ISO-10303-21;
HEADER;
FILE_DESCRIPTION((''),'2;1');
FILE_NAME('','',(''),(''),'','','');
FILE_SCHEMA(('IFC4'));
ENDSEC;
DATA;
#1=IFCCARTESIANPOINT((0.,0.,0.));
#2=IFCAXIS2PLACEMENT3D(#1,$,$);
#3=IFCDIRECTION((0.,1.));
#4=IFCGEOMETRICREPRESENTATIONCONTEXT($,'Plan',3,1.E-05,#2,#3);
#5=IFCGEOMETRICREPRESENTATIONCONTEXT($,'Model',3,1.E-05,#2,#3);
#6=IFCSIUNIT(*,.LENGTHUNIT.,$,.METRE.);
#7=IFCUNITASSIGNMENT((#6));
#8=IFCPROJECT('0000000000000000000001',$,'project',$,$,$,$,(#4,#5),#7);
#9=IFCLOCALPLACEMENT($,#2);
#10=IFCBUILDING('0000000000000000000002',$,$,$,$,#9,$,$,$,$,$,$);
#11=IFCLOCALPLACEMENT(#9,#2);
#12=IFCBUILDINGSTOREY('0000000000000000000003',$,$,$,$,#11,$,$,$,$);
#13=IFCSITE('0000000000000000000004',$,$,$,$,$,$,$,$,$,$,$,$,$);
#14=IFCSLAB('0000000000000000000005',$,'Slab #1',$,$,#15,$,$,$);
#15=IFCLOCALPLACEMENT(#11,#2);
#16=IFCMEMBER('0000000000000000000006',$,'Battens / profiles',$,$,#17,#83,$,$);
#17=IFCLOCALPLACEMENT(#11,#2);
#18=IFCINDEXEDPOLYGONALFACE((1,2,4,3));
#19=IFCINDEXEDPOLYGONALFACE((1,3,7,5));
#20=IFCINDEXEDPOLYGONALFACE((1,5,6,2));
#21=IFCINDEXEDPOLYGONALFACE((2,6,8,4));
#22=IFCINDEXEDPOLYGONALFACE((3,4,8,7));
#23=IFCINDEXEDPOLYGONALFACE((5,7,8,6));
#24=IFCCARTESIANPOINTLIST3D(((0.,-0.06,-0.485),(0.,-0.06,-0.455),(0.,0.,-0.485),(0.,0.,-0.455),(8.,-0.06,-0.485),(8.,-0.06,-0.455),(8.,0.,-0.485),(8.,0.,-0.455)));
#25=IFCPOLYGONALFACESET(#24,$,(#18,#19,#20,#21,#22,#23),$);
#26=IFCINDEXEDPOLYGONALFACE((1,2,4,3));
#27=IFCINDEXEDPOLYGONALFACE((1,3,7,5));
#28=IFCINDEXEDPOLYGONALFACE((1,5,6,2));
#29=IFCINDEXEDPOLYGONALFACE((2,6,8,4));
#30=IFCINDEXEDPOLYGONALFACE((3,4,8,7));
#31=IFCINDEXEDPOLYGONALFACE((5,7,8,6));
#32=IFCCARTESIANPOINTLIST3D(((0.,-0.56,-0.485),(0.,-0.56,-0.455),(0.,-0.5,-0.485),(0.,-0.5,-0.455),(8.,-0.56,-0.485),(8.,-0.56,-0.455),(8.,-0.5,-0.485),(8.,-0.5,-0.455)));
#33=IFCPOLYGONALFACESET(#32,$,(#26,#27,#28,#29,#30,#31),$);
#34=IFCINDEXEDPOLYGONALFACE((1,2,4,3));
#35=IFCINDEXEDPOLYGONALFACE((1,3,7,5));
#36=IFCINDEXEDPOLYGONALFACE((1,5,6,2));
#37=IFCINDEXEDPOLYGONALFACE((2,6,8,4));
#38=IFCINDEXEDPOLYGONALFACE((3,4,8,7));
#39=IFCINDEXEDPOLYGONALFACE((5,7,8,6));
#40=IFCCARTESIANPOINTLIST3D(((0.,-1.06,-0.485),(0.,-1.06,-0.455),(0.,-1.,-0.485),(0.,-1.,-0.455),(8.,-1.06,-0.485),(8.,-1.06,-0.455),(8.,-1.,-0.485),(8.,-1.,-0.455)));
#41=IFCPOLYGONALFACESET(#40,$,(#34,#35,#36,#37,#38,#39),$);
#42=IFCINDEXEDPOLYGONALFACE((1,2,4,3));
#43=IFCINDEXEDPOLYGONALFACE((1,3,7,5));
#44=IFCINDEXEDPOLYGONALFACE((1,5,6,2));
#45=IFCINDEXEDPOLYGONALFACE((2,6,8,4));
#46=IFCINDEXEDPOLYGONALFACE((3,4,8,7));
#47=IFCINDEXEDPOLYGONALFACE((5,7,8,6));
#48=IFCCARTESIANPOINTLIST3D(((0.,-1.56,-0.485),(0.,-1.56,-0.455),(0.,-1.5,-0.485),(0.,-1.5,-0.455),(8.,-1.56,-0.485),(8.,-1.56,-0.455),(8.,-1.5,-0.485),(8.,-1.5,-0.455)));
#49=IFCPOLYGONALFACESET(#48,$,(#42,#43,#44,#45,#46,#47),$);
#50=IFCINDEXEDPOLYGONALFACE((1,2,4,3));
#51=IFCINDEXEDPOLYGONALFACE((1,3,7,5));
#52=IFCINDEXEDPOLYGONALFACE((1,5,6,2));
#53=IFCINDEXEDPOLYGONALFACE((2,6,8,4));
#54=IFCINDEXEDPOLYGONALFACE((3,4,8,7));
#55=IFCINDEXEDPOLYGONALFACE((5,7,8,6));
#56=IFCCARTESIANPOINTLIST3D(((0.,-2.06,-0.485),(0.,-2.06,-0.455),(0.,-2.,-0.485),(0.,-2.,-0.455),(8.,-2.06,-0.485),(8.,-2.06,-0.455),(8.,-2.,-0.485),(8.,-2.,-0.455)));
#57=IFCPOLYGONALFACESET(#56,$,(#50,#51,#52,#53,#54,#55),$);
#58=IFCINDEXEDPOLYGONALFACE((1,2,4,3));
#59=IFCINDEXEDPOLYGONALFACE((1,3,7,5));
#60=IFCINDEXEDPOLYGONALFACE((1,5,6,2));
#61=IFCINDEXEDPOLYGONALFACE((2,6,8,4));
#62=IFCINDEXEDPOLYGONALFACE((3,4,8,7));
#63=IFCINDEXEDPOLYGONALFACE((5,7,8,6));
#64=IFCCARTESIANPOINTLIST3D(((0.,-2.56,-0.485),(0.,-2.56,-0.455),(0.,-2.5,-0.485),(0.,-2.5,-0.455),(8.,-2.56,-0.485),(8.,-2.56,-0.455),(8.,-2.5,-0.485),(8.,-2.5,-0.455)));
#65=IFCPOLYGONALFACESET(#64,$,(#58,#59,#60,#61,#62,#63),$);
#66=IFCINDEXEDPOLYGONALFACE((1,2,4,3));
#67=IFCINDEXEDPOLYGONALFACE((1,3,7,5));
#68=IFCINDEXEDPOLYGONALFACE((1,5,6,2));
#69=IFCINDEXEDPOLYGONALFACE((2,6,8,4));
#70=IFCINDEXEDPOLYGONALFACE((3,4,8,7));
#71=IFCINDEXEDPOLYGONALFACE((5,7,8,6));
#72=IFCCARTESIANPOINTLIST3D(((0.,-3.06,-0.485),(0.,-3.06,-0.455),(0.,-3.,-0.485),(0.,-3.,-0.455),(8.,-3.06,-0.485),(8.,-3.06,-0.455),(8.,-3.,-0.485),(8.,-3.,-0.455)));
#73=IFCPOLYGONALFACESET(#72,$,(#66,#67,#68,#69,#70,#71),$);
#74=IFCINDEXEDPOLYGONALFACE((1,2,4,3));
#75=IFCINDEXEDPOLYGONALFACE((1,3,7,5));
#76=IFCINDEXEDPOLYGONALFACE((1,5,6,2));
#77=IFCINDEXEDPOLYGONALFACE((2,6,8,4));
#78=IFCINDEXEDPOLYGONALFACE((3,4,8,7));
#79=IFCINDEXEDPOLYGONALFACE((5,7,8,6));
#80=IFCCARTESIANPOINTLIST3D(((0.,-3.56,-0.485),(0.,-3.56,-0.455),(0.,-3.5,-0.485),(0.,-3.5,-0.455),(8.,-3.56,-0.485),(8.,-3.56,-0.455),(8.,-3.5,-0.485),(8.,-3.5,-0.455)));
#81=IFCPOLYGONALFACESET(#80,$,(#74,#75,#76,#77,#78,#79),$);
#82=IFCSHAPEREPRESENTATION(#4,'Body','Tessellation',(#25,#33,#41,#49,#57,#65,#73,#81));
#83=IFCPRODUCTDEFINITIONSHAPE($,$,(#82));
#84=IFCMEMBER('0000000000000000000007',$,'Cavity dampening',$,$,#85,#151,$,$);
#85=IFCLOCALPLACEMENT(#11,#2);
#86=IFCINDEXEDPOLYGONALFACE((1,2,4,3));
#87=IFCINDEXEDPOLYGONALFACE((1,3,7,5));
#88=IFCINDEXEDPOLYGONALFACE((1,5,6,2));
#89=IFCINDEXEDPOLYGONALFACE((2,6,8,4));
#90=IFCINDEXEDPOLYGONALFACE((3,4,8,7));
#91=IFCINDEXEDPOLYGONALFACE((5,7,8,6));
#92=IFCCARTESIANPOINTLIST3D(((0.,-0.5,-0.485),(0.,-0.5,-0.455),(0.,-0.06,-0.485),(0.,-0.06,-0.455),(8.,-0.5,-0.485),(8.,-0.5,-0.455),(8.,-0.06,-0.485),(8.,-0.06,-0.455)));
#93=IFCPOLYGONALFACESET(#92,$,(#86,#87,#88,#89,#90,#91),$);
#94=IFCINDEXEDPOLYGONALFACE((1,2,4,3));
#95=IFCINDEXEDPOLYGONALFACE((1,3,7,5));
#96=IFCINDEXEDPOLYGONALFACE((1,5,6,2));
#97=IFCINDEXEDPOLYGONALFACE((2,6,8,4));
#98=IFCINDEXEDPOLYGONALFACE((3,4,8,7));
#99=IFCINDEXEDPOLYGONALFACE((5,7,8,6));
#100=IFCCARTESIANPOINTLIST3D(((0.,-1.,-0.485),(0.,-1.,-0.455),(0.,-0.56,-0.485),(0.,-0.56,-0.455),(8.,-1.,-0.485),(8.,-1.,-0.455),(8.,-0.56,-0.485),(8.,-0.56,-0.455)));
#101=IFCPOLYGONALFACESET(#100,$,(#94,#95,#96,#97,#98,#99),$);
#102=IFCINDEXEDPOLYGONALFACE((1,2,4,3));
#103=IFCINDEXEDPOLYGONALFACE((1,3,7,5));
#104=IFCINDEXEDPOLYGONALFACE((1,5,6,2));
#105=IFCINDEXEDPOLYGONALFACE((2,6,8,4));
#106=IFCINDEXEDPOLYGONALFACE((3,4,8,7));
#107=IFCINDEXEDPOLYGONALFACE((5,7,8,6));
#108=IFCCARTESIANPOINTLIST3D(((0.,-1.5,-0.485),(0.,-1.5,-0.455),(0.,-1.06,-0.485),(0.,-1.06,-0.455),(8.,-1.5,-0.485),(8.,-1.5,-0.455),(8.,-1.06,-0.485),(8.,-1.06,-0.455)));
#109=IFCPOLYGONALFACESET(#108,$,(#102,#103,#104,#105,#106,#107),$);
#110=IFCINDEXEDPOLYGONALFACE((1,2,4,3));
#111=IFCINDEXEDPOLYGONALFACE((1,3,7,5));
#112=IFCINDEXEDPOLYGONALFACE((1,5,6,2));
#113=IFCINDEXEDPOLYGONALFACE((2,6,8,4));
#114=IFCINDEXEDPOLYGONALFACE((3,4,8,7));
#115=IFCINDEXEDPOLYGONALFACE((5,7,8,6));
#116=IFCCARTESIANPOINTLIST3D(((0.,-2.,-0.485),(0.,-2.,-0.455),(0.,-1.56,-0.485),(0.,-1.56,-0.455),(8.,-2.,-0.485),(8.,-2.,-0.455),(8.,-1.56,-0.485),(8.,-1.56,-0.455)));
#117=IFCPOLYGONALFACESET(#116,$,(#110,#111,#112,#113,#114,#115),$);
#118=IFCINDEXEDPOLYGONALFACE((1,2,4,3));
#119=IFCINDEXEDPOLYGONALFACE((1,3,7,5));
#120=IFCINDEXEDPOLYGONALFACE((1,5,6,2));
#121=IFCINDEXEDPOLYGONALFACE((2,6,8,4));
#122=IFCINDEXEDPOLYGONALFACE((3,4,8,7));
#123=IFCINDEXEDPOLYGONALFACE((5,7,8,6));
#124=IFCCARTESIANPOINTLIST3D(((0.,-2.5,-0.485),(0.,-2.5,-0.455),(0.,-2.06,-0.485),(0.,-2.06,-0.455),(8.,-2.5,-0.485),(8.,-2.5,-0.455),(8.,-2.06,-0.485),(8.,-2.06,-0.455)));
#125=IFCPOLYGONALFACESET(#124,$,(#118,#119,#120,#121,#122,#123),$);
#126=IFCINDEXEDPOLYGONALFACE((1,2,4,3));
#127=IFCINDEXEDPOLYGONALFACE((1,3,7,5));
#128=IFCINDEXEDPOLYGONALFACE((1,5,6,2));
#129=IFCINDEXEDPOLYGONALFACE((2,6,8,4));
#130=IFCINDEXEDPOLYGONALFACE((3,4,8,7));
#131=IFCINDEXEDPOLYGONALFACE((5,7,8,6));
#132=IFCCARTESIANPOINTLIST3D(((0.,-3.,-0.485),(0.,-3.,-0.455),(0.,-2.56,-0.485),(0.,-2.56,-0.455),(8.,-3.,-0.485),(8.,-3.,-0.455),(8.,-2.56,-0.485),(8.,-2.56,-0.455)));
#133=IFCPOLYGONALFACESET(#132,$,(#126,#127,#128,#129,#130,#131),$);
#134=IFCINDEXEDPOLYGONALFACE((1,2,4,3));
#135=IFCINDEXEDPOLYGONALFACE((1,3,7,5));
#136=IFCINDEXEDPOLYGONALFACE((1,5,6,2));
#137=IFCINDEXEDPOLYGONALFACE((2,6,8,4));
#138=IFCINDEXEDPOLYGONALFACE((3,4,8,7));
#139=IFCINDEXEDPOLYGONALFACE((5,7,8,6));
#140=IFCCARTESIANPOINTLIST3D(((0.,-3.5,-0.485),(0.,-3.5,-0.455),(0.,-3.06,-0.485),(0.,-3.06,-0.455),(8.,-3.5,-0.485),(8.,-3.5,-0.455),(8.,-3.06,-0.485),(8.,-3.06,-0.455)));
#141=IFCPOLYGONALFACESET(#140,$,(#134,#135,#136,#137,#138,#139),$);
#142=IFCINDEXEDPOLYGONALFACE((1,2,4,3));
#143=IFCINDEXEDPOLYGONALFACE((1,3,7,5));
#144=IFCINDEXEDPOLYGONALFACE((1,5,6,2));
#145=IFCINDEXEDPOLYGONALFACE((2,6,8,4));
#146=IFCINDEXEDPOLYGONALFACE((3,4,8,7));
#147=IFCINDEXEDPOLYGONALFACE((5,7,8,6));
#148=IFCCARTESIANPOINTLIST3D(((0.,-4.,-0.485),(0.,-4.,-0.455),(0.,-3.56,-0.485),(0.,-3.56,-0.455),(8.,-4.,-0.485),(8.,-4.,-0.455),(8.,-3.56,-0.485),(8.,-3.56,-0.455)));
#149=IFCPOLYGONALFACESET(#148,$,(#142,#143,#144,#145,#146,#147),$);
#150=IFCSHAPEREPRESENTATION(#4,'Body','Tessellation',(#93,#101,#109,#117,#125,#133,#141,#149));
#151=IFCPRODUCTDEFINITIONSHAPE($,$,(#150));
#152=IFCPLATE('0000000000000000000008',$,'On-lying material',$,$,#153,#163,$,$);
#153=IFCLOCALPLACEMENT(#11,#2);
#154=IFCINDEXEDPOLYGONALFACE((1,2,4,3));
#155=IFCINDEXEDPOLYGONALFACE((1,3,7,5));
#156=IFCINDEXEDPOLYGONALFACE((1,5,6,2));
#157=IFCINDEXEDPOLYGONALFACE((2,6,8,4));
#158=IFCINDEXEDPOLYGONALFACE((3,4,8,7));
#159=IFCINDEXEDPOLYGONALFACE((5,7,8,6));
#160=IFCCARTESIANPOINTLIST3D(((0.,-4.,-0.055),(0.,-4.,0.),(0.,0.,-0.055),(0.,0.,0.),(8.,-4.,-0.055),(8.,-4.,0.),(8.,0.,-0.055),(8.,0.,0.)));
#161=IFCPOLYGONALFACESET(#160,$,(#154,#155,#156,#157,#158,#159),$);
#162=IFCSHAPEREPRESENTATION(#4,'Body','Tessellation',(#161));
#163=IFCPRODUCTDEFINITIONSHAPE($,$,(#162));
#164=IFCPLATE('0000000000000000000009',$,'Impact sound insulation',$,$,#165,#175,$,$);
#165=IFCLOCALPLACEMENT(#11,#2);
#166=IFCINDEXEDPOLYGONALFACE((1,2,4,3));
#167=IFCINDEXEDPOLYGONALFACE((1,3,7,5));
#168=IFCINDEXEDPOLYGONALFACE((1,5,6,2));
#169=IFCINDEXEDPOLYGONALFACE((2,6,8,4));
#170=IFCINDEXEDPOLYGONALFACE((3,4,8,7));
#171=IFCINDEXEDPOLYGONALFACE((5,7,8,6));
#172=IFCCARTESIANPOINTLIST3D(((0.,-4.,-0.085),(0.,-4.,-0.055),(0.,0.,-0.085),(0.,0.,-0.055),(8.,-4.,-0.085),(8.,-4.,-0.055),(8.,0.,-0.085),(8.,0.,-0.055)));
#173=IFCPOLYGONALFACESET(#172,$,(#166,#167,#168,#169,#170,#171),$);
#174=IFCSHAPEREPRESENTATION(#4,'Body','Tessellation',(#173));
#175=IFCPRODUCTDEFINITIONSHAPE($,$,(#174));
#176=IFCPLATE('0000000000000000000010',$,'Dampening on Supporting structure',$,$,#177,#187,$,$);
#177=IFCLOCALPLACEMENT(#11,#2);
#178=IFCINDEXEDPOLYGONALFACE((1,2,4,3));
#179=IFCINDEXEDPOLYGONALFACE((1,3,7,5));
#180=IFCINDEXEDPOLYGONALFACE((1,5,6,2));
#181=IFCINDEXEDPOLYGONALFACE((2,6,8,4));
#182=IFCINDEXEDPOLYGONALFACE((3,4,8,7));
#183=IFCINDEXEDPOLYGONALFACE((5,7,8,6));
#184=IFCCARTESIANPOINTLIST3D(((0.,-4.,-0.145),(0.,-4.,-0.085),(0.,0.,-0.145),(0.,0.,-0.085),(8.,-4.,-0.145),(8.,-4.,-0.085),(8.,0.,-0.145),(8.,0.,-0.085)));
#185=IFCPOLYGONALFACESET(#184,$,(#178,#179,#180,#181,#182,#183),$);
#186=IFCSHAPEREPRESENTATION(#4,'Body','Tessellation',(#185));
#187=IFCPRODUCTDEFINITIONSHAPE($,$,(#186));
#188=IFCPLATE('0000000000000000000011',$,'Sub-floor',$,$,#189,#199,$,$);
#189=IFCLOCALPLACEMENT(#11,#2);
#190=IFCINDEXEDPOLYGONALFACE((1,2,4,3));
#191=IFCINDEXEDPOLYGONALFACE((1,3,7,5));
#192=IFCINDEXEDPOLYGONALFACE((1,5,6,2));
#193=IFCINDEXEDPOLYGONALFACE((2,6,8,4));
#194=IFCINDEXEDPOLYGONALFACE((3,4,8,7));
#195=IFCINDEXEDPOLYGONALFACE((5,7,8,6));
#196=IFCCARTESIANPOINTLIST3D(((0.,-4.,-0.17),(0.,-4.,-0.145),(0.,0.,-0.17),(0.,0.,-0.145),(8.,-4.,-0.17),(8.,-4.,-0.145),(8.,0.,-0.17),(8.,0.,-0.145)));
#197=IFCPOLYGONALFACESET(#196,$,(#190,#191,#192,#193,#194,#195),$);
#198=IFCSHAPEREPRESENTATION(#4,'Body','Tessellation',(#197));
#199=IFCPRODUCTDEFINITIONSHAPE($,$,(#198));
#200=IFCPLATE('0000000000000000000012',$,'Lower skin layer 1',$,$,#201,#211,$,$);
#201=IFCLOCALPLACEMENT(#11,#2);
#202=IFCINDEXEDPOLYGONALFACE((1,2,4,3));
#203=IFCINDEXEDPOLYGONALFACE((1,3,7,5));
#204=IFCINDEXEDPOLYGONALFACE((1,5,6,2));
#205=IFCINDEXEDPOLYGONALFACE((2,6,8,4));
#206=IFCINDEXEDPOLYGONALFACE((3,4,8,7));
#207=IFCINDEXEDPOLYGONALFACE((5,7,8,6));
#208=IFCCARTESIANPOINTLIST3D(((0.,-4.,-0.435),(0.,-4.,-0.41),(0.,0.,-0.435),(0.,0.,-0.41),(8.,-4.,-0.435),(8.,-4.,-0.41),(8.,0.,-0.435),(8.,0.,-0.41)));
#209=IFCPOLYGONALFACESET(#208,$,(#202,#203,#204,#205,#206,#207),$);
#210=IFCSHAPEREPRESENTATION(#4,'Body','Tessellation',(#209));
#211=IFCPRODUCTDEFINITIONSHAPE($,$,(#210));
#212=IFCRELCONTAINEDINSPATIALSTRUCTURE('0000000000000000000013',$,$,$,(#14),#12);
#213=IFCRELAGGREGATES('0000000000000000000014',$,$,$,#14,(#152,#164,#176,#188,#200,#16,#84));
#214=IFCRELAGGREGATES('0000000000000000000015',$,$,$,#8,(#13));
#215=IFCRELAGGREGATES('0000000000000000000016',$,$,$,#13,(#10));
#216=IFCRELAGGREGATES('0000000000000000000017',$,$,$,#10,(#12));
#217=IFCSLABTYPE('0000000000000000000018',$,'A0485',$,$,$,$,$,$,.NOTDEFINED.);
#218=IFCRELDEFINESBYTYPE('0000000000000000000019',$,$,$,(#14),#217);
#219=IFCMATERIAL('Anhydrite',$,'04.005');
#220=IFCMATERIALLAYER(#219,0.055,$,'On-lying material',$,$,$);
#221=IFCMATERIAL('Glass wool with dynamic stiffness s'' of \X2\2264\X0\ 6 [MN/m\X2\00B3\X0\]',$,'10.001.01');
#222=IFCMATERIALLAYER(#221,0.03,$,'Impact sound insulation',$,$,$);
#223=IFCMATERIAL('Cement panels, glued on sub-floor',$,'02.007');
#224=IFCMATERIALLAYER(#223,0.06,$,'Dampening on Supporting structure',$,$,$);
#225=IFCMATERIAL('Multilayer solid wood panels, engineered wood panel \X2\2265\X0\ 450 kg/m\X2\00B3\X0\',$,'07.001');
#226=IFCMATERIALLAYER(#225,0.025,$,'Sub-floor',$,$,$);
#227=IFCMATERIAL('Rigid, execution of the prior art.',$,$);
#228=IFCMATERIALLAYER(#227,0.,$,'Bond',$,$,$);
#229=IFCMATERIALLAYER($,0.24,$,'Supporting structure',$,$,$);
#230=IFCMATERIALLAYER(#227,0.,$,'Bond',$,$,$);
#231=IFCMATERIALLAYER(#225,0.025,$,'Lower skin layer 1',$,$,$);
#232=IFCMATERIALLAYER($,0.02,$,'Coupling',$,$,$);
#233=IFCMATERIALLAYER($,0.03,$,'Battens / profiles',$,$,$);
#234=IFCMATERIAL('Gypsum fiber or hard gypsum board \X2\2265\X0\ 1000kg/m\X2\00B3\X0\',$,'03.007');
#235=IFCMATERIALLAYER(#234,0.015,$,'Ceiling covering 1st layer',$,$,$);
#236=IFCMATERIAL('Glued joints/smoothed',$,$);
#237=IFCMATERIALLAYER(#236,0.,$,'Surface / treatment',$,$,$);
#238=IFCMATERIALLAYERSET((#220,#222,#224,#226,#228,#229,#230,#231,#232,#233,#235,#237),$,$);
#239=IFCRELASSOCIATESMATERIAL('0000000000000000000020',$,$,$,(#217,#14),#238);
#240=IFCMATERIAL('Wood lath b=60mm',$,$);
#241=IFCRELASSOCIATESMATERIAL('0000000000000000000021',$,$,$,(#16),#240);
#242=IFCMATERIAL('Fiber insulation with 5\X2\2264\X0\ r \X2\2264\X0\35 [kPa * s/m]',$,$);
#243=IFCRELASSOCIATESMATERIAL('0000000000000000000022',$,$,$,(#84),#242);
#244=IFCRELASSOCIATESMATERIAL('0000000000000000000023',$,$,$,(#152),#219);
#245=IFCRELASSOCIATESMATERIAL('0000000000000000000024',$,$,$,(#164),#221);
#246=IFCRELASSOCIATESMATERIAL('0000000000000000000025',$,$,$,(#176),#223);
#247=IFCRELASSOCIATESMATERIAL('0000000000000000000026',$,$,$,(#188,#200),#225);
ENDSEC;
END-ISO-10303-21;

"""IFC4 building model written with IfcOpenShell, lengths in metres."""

from ifc_helpers import new_model, si_unit, direction, frame, frame_2d, origin, origin_with_axes, place, context, project, spatial, rectangle, extrude, material, layer, layer_set, type_object, element, aggregate, save


model = new_model("IFC4")

# Units and contexts
plan_context = context("Plan", 3, precision=1e-05, world=origin(), true_north=direction((0.0, 1.0)))
model_context = context("Model", 3, precision=1e-05, world=origin(), true_north=direction((0.0, 1.0)))
ifc_project = project(units=[si_unit("LENGTHUNIT", "METRE")], contexts=[plan_context, model_context])

# Site, building, storey
site = spatial("IfcSite", under=ifc_project)
building_placement = place(None, origin())
building = spatial("IfcBuilding", under=site, at=building_placement)
storey_placement = place(building_placement, origin())
storey = spatial("IfcBuildingStorey", under=building, at=storey_placement)

# Slab, members, plates
ifc_material_1 = material(Name="Anhydrite", Category="04.005")
ifc_layer_1 = layer(ifc_material_1, 0.055, Name="On-lying material")
ifc_material_2 = material(Name="Glass wool with dynamic stiffness s' of ≤ 6 [MN/m³]", Category="10.001.01")
ifc_layer_2 = layer(ifc_material_2, 0.03, Name="Impact sound insulation")
ifc_material_3 = material(Name="Cement panels, glued on sub-floor", Category="02.007")
ifc_layer_3 = layer(ifc_material_3, 0.06, Name="Dampening on Supporting structure")
ifc_material_4 = material(Name="Multilayer solid wood panels, engineered wood panel ≥ 450 kg/m³", Category="07.001")
ifc_layer_4 = layer(ifc_material_4, 0.025, Name="Sub-floor")
ifc_material_5 = material(Name="Rigid, execution of the prior art.")
ifc_layer_5 = layer(ifc_material_5, 0.0, Name="Bond")
ifc_layer_6 = layer(None, 0.24, Name="Supporting structure")
ifc_layer_7 = layer(ifc_material_5, 0.0, Name="Bond")
ifc_layer_8 = layer(ifc_material_4, 0.025, Name="Lower skin layer 1")
ifc_layer_9 = layer(None, 0.02, Name="Coupling")
ifc_layer_10 = layer(None, 0.03, Name="Battens / profiles")
ifc_material_6 = material(Name="Gypsum fiber or hard gypsum board ≥ 1000kg/m³", Category="03.007")
ifc_layer_11 = layer(ifc_material_6, 0.015, Name="Ceiling covering 1st layer")
ifc_material_7 = material(Name="Glued joints/smoothed")
ifc_layer_12 = layer(ifc_material_7, 0.0, Name="Surface / treatment")
ifc_layer_set = layer_set([ifc_layer_1, ifc_layer_2, ifc_layer_3, ifc_layer_4, ifc_layer_5, ifc_layer_6, ifc_layer_7, ifc_layer_8, ifc_layer_9, ifc_layer_10, ifc_layer_11, ifc_layer_12])
slab_type = type_object("IfcSlabType", Name="A0485", PredefinedType="NOTDEFINED", material=ifc_layer_set)
slab_placement = place(None, frame((0.0, 0.0, 0.0), z_axis=(0.0, 0.0, -1.0), x_axis=(1.0, 0.0, 0.0)))
slab = element("IfcSlab", 1, at=slab_placement, inside=storey, type_object=slab_type, material=ifc_layer_set, Name="Slab #1")
ifc_material_8 = material(Name="Fiber insulation with 5≤ r ≤35 [kPa * s/m]")
ifc_material_9 = material(Name="Wood lath b=60mm")
member_1_placement = place(slab_placement, origin())
member_1 = element("IfcMember", 2, at=member_1_placement, material=ifc_material_9, Name="Battens / profiles", context=plan_context, shape_type="SweptSolid", body=[
    extrude(rectangle(XDim=0.06, YDim=0.03, at=frame_2d((0.03, 0.015), x_axis=(1.0, 0.0))), frame((0.0, 0.0, 0.455), z_axis=(1.0, 0.0, 0.0), x_axis=(0.0, 1.0, 0.0)), (0.0, 0.0, 1.0), 8.0),
    extrude(rectangle(XDim=0.06, YDim=0.03, at=frame_2d((0.03, 0.015), x_axis=(1.0, 0.0))), frame((0.0, 0.5, 0.455), z_axis=(1.0, 0.0, 0.0), x_axis=(0.0, 1.0, 0.0)), (0.0, 0.0, 1.0), 8.0),
    extrude(rectangle(XDim=0.06, YDim=0.03, at=frame_2d((0.03, 0.015), x_axis=(1.0, 0.0))), frame((0.0, 1.0, 0.455), z_axis=(1.0, 0.0, 0.0), x_axis=(0.0, 1.0, 0.0)), (0.0, 0.0, 1.0), 8.0),
    extrude(rectangle(XDim=0.06, YDim=0.03, at=frame_2d((0.03, 0.015), x_axis=(1.0, 0.0))), frame((0.0, 1.5, 0.455), z_axis=(1.0, 0.0, 0.0), x_axis=(0.0, 1.0, 0.0)), (0.0, 0.0, 1.0), 8.0),
    extrude(rectangle(XDim=0.06, YDim=0.03, at=frame_2d((0.03, 0.015), x_axis=(1.0, 0.0))), frame((0.0, 2.0, 0.455), z_axis=(1.0, 0.0, 0.0), x_axis=(0.0, 1.0, 0.0)), (0.0, 0.0, 1.0), 8.0),
    extrude(rectangle(XDim=0.06, YDim=0.03, at=frame_2d((0.03, 0.015), x_axis=(1.0, 0.0))), frame((0.0, 2.5, 0.455), z_axis=(1.0, 0.0, 0.0), x_axis=(0.0, 1.0, 0.0)), (0.0, 0.0, 1.0), 8.0),
    extrude(rectangle(XDim=0.06, YDim=0.03, at=frame_2d((0.03, 0.015), x_axis=(1.0, 0.0))), frame((0.0, 3.0, 0.455), z_axis=(1.0, 0.0, 0.0), x_axis=(0.0, 1.0, 0.0)), (0.0, 0.0, 1.0), 8.0),
    extrude(rectangle(XDim=0.06, YDim=0.03, at=frame_2d((0.03, 0.015), x_axis=(1.0, 0.0))), frame((0.0, 3.5, 0.455), z_axis=(1.0, 0.0, 0.0), x_axis=(0.0, 1.0, 0.0)), (0.0, 0.0, 1.0), 8.0),
])
member_2_placement = place(slab_placement, origin())
member_2 = element("IfcMember", 3, at=member_2_placement, material=ifc_material_8, Name="Cavity dampening", context=plan_context, shape_type="SweptSolid", body=[
    extrude(rectangle(XDim=0.44, YDim=0.03, at=frame_2d((0.22, 0.015), x_axis=(1.0, 0.0))), frame((0.0, 0.06, 0.455), z_axis=(1.0, 0.0, 0.0), x_axis=(0.0, 1.0, 0.0)), (0.0, 0.0, 1.0), 8.0),
    extrude(rectangle(XDim=0.44, YDim=0.03, at=frame_2d((0.22, 0.015), x_axis=(1.0, 0.0))), frame((0.0, 0.56, 0.455), z_axis=(1.0, 0.0, 0.0), x_axis=(0.0, 1.0, 0.0)), (0.0, 0.0, 1.0), 8.0),
    extrude(rectangle(XDim=0.44, YDim=0.03, at=frame_2d((0.22, 0.015), x_axis=(1.0, 0.0))), frame((0.0, 1.06, 0.455), z_axis=(1.0, 0.0, 0.0), x_axis=(0.0, 1.0, 0.0)), (0.0, 0.0, 1.0), 8.0),
    extrude(rectangle(XDim=0.44, YDim=0.03, at=frame_2d((0.22, 0.015), x_axis=(1.0, 0.0))), frame((0.0, 1.56, 0.455), z_axis=(1.0, 0.0, 0.0), x_axis=(0.0, 1.0, 0.0)), (0.0, 0.0, 1.0), 8.0),
    extrude(rectangle(XDim=0.44, YDim=0.03, at=frame_2d((0.22, 0.015), x_axis=(1.0, 0.0))), frame((0.0, 2.06, 0.455), z_axis=(1.0, 0.0, 0.0), x_axis=(0.0, 1.0, 0.0)), (0.0, 0.0, 1.0), 8.0),
    extrude(rectangle(XDim=0.44, YDim=0.03, at=frame_2d((0.22, 0.015), x_axis=(1.0, 0.0))), frame((0.0, 2.56, 0.455), z_axis=(1.0, 0.0, 0.0), x_axis=(0.0, 1.0, 0.0)), (0.0, 0.0, 1.0), 8.0),
    extrude(rectangle(XDim=0.44, YDim=0.03, at=frame_2d((0.22, 0.015), x_axis=(1.0, 0.0))), frame((0.0, 3.06, 0.455), z_axis=(1.0, 0.0, 0.0), x_axis=(0.0, 1.0, 0.0)), (0.0, 0.0, 1.0), 8.0),
    extrude(rectangle(XDim=0.44, YDim=0.03, at=frame_2d((0.22, 0.015), x_axis=(1.0, 0.0))), frame((0.0, 3.56, 0.455), z_axis=(1.0, 0.0, 0.0), x_axis=(0.0, 1.0, 0.0)), (0.0, 0.0, 1.0), 8.0),
])
plate_1_placement = place(slab_placement, origin())
plate_1 = element("IfcPlate", 4, at=plate_1_placement, material=ifc_material_1, Name="On-lying material", context=plan_context, shape_type="SweptSolid", body=[
    extrude(rectangle(XDim=8.0, YDim=4.0, at=frame_2d((4.0, 2.0), x_axis=(1.0, 0.0))), origin_with_axes(), (0.0, 0.0, 1.0), 0.055),
])
plate_2_placement = place(slab_placement, origin())
plate_2 = element("IfcPlate", 5, at=plate_2_placement, material=ifc_material_2, Name="Impact sound insulation", context=plan_context, shape_type="SweptSolid", body=[
    extrude(rectangle(XDim=8.0, YDim=4.0, at=frame_2d((4.0, 2.0), x_axis=(1.0, 0.0))), frame((0.0, 0.0, 0.055), z_axis=(0.0, 0.0, 1.0), x_axis=(1.0, 0.0, 0.0)), (0.0, 0.0, 1.0), 0.03),
])
plate_3_placement = place(slab_placement, origin())
plate_3 = element("IfcPlate", 6, at=plate_3_placement, material=ifc_material_3, Name="Dampening on Supporting structure", context=plan_context, shape_type="SweptSolid", body=[
    extrude(rectangle(XDim=8.0, YDim=4.0, at=frame_2d((4.0, 2.0), x_axis=(1.0, 0.0))), frame((0.0, 0.0, 0.085), z_axis=(0.0, 0.0, 1.0), x_axis=(1.0, 0.0, 0.0)), (0.0, 0.0, 1.0), 0.06),
])
plate_4_placement = place(slab_placement, origin())
plate_4 = element("IfcPlate", 7, at=plate_4_placement, material=ifc_material_4, Name="Sub-floor", context=plan_context, shape_type="SweptSolid", body=[
    extrude(rectangle(XDim=8.0, YDim=4.0, at=frame_2d((4.0, 2.0), x_axis=(1.0, 0.0))), frame((0.0, 0.0, 0.145), z_axis=(0.0, 0.0, 1.0), x_axis=(1.0, 0.0, 0.0)), (0.0, 0.0, 1.0), 0.025),
])
plate_5_placement = place(slab_placement, origin())
plate_5 = element("IfcPlate", 8, at=plate_5_placement, material=ifc_material_4, Name="Lower skin layer 1", context=plan_context, shape_type="SweptSolid", body=[
    extrude(rectangle(XDim=8.0, YDim=4.0, at=frame_2d((4.0, 2.0), x_axis=(1.0, 0.0))), frame((0.0, 0.0, 0.41), z_axis=(0.0, 0.0, 1.0), x_axis=(1.0, 0.0, 0.0)), (0.0, 0.0, 1.0), 0.025),
])
aggregate(slab, [plate_1, plate_2, plate_3, plate_4, plate_5, member_1, member_2])

save(model, "model.ifc")
